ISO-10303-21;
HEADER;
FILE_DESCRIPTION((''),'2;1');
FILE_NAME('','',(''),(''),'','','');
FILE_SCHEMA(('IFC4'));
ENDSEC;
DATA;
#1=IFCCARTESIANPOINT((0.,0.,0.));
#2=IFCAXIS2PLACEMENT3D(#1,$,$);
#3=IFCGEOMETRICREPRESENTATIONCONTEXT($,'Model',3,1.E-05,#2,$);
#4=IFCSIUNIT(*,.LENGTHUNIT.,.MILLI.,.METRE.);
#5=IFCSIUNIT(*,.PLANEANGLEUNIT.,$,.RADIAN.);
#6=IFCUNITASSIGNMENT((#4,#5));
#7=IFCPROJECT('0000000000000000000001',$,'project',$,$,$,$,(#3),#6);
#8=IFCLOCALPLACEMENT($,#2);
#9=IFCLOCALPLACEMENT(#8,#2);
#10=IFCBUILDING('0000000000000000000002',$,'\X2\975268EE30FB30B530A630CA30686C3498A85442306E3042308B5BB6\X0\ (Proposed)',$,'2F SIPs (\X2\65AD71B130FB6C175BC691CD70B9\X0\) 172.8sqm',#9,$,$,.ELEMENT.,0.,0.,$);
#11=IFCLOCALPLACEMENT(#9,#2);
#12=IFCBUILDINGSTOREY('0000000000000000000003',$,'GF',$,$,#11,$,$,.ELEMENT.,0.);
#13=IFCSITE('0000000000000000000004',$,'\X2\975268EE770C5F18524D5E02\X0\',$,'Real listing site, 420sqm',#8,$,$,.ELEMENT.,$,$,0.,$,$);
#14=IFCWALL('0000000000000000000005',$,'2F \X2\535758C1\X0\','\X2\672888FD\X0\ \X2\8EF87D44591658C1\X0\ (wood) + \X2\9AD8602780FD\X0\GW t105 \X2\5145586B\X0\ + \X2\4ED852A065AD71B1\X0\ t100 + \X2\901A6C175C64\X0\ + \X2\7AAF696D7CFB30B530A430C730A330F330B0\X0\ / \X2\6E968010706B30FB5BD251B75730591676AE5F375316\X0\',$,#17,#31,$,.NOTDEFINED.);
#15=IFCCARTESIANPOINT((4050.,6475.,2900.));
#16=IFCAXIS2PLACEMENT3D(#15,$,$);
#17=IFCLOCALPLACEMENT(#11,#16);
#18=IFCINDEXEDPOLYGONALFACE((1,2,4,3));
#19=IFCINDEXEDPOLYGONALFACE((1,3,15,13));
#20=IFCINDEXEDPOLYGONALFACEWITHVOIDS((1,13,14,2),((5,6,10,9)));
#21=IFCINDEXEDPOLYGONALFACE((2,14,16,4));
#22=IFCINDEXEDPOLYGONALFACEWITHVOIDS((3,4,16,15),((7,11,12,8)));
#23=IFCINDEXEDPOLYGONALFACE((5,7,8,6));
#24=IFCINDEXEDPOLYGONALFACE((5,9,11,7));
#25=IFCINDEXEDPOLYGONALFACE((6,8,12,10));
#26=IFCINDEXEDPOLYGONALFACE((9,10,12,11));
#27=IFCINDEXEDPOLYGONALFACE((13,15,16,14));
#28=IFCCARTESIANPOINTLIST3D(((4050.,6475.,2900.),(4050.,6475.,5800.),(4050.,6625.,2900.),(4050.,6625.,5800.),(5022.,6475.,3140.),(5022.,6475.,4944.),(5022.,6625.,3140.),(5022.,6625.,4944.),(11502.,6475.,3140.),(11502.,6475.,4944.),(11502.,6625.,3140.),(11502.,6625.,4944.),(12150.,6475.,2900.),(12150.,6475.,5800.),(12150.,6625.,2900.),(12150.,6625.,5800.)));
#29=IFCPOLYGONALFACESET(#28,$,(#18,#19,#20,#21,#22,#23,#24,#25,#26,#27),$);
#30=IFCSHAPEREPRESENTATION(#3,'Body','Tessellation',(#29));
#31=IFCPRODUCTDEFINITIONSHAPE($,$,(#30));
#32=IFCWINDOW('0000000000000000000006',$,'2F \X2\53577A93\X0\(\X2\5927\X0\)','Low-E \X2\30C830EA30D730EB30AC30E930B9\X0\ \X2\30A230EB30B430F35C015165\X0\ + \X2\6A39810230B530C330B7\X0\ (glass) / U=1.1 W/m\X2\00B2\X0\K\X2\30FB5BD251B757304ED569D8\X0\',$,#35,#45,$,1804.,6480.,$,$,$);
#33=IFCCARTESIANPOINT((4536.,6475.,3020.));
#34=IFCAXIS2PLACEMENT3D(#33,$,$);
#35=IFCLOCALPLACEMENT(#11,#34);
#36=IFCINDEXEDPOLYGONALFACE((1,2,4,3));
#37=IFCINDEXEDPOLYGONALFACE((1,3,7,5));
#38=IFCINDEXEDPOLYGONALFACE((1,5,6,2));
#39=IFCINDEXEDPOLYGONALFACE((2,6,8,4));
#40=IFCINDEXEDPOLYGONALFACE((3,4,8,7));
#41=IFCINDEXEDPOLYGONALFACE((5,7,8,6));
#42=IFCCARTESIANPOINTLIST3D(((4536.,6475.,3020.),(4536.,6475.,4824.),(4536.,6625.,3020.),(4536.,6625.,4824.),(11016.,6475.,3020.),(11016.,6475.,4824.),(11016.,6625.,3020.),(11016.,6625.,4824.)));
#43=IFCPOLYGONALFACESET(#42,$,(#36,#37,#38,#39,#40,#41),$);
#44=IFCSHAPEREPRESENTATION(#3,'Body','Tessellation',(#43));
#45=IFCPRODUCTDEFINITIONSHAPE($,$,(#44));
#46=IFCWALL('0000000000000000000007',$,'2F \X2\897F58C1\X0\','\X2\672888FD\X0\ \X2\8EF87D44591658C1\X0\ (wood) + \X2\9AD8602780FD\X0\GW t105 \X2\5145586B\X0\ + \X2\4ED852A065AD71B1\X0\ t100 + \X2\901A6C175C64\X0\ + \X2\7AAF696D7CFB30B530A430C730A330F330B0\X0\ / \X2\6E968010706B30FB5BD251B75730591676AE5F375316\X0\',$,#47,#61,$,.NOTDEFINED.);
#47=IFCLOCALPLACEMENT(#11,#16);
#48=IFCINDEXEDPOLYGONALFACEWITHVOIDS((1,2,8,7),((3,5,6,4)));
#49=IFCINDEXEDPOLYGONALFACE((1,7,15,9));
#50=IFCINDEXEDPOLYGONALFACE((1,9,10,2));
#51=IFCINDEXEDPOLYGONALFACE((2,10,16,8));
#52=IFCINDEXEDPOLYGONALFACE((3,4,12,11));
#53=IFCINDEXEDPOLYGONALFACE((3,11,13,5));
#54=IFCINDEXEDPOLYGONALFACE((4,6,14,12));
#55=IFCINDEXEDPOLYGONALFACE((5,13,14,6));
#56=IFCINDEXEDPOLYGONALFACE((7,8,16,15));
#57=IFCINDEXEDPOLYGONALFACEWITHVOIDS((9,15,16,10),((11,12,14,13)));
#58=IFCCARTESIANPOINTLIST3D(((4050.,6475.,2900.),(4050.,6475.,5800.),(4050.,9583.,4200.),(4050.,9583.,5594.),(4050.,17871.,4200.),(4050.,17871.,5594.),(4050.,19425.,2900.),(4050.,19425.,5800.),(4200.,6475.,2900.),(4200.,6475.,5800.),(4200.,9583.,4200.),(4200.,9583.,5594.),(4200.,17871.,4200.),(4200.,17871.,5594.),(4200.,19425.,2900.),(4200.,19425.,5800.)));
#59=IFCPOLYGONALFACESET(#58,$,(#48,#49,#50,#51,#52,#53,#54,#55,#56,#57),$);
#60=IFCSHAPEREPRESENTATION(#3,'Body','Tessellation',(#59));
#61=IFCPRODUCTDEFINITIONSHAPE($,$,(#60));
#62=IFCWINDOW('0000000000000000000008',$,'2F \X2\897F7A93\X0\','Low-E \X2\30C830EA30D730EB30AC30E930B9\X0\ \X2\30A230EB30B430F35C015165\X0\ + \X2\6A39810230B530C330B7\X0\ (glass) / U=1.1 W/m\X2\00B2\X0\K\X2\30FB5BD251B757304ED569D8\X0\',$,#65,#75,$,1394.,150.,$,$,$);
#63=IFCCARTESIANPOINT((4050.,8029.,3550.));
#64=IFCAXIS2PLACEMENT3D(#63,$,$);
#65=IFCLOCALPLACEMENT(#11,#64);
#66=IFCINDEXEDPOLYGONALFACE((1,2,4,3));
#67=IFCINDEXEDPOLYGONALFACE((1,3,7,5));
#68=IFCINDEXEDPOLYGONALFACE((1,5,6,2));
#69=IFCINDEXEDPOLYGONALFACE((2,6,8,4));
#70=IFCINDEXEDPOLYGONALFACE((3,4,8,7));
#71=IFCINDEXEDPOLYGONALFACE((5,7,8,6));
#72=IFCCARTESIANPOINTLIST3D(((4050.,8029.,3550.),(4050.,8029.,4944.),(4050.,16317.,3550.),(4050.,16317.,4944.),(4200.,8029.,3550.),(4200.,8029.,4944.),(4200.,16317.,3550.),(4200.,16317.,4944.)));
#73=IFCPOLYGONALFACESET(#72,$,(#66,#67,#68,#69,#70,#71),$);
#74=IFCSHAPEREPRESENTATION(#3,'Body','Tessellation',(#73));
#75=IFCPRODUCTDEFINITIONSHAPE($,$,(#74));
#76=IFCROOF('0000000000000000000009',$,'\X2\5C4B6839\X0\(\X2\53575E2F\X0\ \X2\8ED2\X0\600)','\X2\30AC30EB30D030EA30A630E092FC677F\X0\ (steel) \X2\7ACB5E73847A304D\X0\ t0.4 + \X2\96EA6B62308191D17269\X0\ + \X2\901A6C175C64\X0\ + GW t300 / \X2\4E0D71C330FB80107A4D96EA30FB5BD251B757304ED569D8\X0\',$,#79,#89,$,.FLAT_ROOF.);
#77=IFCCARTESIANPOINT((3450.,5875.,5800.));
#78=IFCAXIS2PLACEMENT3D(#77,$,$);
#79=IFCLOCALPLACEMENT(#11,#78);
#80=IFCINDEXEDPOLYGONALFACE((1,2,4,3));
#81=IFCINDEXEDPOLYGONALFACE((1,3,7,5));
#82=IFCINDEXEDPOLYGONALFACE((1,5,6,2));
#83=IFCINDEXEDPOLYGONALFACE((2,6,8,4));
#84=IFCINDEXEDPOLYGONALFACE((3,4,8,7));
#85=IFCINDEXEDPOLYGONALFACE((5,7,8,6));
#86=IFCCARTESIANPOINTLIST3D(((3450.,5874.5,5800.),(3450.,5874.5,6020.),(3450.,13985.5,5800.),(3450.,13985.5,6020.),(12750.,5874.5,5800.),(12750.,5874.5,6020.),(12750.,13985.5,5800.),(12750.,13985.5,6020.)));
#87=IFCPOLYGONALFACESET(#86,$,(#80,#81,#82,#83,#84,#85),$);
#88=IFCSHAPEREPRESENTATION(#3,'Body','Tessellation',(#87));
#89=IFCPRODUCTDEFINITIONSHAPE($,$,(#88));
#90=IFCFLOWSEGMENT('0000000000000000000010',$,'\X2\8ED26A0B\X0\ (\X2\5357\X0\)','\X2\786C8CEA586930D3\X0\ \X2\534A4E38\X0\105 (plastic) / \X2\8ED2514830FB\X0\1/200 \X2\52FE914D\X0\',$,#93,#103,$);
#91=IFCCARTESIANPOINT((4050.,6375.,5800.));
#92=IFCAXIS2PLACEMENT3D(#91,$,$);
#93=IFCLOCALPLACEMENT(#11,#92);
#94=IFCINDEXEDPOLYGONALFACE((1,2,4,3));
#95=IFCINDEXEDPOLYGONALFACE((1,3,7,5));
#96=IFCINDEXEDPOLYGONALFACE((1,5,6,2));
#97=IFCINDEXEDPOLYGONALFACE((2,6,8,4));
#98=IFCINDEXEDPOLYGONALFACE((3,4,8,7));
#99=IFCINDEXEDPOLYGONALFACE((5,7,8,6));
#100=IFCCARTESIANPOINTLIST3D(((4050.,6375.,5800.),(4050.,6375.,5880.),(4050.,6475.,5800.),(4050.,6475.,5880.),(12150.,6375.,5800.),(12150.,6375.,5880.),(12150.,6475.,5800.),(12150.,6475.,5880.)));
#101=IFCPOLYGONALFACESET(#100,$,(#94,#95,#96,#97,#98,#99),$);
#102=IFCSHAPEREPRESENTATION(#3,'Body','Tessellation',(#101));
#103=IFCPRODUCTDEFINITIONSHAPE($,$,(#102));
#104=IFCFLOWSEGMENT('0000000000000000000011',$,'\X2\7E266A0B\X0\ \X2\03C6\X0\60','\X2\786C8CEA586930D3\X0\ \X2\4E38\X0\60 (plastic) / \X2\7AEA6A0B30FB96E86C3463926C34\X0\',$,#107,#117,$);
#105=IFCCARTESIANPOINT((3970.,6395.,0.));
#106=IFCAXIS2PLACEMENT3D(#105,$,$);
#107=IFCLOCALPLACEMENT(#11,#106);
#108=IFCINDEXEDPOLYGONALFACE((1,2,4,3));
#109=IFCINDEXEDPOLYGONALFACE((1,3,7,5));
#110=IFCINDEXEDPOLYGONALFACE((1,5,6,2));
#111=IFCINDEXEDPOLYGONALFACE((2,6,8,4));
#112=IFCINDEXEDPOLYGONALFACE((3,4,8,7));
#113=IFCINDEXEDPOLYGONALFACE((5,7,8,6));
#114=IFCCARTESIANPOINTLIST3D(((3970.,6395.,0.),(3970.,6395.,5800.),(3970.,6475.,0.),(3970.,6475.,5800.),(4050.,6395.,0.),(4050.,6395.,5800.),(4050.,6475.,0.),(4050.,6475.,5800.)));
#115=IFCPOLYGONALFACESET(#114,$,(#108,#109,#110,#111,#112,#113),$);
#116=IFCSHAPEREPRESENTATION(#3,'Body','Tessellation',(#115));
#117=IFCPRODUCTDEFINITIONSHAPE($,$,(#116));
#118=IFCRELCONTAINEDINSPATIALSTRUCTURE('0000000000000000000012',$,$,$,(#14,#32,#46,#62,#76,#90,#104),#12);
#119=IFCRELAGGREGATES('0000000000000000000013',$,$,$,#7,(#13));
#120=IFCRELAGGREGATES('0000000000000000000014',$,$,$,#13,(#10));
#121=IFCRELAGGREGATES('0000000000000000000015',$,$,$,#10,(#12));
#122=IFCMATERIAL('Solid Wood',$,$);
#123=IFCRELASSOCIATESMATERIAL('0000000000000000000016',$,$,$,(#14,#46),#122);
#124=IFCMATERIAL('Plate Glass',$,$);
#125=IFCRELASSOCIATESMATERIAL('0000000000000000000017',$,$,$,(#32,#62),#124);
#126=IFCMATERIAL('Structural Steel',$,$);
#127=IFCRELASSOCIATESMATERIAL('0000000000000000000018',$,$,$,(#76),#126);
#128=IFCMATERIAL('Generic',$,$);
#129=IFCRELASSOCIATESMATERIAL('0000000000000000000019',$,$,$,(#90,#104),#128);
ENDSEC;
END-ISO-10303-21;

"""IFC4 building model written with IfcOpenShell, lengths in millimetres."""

from ifc_helpers import new_model, si_unit, frame, frame_2d, origin, place, context, project, spatial, rectangle, extrude, material, element, fill, save


model = new_model("IFC4")

# Units and contexts
model_context = context("Model", 3, precision=1e-05, world=origin())
ifc_project = project(units=[si_unit("LENGTHUNIT", "METRE", prefix="MILLI"), si_unit("PLANEANGLEUNIT", "RADIAN")], contexts=[model_context])

# Site, building, storey
site_placement = place(None, origin())
site = spatial("IfcSite", under=ifc_project, at=site_placement, Name="青森県弘前市", ObjectType="Real listing site, 420sqm", CompositionType="ELEMENT", RefElevation=0.0)
building_placement = place(site_placement, origin())
building = spatial("IfcBuilding", under=site, at=building_placement, Name="青森・サウナと水風呂のある家 (Proposed)", ObjectType="2F SIPs (断熱・気密重点) 172.8sqm", CompositionType="ELEMENT", ElevationOfRefHeight=0.0, ElevationOfTerrain=0.0)
storey_placement = place(building_placement, origin())
storey = spatial("IfcBuildingStorey", under=building, at=storey_placement, Name="GF", CompositionType="ELEMENT", Elevation=0.0)

# Shared definitions
ifc_material_1 = material(Name="Solid Wood")

# Shared definitions
ifc_material_2 = material(Name="Plate Glass")

# Walls, openings, windows
wall_1_placement = place(storey_placement, frame((4050.0, 6475.0, 2900.0)))
wall_1 = element("IfcWall", 1, at=wall_1_placement, inside=storey, material=ifc_material_1, Name="2F 南壁", Description="木製 軸組外壁 (wood) + 高性能GW t105 充填 + 付加断熱 t100 + 通気層 + 窯業系サイディング / 準耐火・寒冷地外皮強化", PredefinedType="NOTDEFINED", context=model_context, shape_type="SweptSolid", body=[
    extrude(rectangle(XDim=8100.0, YDim=150.0, at=frame_2d((4050.0, 75.0))), frame((4050.0, 6475.0, 2900.0)), (0.0, 0.0, 1.0), 2900.0),
])
opening_1_placement = place(storey_placement, frame((4536.0, 6475.0, 3020.0)))
opening_1 = element("IfcOpeningElement", 2, at=opening_1_placement, cuts=wall_1, PredefinedType="NOTDEFINED", context=model_context, shape_type="SweptSolid", body=[
    extrude(rectangle(XDim=6480.0, YDim=150.0, at=frame_2d((3240.0, 75.0))), frame((4536.0, 6475.0, 3020.0)), (0.0, 0.0, 1.0), 1804.0),
])
window_1_placement = place(storey_placement, frame((4536.0, 6475.0, 3020.0)))
window_1 = element("IfcWindow", 3, at=window_1_placement, inside=storey, material=ifc_material_2, Name="2F 南窓(大)", Description="Low-E トリプルガラス アルゴン封入 + 樹脂サッシ (glass) / U=1.1 W/m²K・寒冷地仕様", OverallHeight=1804.0, OverallWidth=6480.0, context=model_context, shape_type="SweptSolid", body=[
    extrude(rectangle(XDim=6480.0, YDim=150.0, at=frame_2d((3240.0, 75.0))), frame((4536.0, 6475.0, 3020.0)), (0.0, 0.0, 1.0), 1804.0),
])
fill(opening_1, window_1)
wall_2_placement = place(storey_placement, frame((4050.0, 6475.0, 2900.0)))
wall_2 = element("IfcWall", 4, at=wall_2_placement, inside=storey, material=ifc_material_1, Name="2F 西壁", Description="木製 軸組外壁 (wood) + 高性能GW t105 充填 + 付加断熱 t100 + 通気層 + 窯業系サイディング / 準耐火・寒冷地外皮強化", PredefinedType="NOTDEFINED", context=model_context, shape_type="SweptSolid", body=[
    extrude(rectangle(XDim=150.0, YDim=12950.0, at=frame_2d((75.0, 6475.0))), frame((4050.0, 6475.0, 2900.0)), (0.0, 0.0, 1.0), 2900.0),
])
opening_2_placement = place(storey_placement, frame((4050.0, 8029.0, 3550.0)))
opening_2 = element("IfcOpeningElement", 5, at=opening_2_placement, cuts=wall_2, PredefinedType="NOTDEFINED", context=model_context, shape_type="SweptSolid", body=[
    extrude(rectangle(XDim=150.0, YDim=8288.0, at=frame_2d((75.0, 4144.0))), frame((4050.0, 8029.0, 3550.0)), (0.0, 0.0, 1.0), 1394.0),
])
window_2_placement = place(storey_placement, frame((4050.0, 8029.0, 3550.0)))
window_2 = element("IfcWindow", 6, at=window_2_placement, inside=storey, material=ifc_material_2, Name="2F 西窓", Description="Low-E トリプルガラス アルゴン封入 + 樹脂サッシ (glass) / U=1.1 W/m²K・寒冷地仕様", OverallHeight=1394.0, OverallWidth=150.0, context=model_context, shape_type="SweptSolid", body=[
    extrude(rectangle(XDim=150.0, YDim=8288.0, at=frame_2d((75.0, 4144.0))), frame((4050.0, 8029.0, 3550.0)), (0.0, 0.0, 1.0), 1394.0),
])
fill(opening_2, window_2)

# Roof
ifc_material_3 = material(Name="Structural Steel")
for number, where, name in (
    (7, (3450.0, 5875.0, 5800.0), "屋根(南帯 軒600)"),
):
    element("IfcRoof", number, at=place(storey_placement, frame(where)), inside=storey, material=ifc_material_3, Name=name, Description="ガルバリウム鋼板 (steel) 立平葺き t0.4 + 雪止め金物 + 通気層 + GW t300 / 不燃・耐積雪・寒冷地仕様", PredefinedType="FLAT_ROOF", context=model_context, shape_type="SweptSolid", body=[
        extrude(rectangle(XDim=9300.0, YDim=8111.0, at=frame_2d((4650.0, 4055.0))), frame((3450.0, 5875.0, 5800.0)), (0.0, 0.0, 1.0), 220.0),
    ])

# Flow segments
ifc_material_4 = material(Name="Generic")
flow_segment_1_placement = place(storey_placement, frame((4050.0, 6375.0, 5800.0)))
element("IfcFlowSegment", 8, at=flow_segment_1_placement, inside=storey, material=ifc_material_4, Name="軒樋 (南)", Description="硬質塩ビ 半丸105 (plastic) / 軒先・1/200 勾配", context=model_context, shape_type="SweptSolid", body=[
    extrude(rectangle(XDim=8100.0, YDim=100.0, at=frame_2d((4050.0, 50.0))), frame((4050.0, 6375.0, 5800.0)), (0.0, 0.0, 1.0), 80.0),
])
flow_segment_2_placement = place(storey_placement, frame((3970.0, 6395.0, 0.0)))
element("IfcFlowSegment", 9, at=flow_segment_2_placement, inside=storey, material=ifc_material_4, Name="縦樋 φ60", Description="硬質塩ビ 丸60 (plastic) / 竪樋・雨水排水", context=model_context, shape_type="SweptSolid", body=[
    extrude(rectangle(XDim=80.0, YDim=80.0, at=frame_2d((40.0, 40.0))), frame((3970.0, 6395.0, 0.0)), (0.0, 0.0, 1.0), 5800.0),
])

save(model, "model.ifc")
